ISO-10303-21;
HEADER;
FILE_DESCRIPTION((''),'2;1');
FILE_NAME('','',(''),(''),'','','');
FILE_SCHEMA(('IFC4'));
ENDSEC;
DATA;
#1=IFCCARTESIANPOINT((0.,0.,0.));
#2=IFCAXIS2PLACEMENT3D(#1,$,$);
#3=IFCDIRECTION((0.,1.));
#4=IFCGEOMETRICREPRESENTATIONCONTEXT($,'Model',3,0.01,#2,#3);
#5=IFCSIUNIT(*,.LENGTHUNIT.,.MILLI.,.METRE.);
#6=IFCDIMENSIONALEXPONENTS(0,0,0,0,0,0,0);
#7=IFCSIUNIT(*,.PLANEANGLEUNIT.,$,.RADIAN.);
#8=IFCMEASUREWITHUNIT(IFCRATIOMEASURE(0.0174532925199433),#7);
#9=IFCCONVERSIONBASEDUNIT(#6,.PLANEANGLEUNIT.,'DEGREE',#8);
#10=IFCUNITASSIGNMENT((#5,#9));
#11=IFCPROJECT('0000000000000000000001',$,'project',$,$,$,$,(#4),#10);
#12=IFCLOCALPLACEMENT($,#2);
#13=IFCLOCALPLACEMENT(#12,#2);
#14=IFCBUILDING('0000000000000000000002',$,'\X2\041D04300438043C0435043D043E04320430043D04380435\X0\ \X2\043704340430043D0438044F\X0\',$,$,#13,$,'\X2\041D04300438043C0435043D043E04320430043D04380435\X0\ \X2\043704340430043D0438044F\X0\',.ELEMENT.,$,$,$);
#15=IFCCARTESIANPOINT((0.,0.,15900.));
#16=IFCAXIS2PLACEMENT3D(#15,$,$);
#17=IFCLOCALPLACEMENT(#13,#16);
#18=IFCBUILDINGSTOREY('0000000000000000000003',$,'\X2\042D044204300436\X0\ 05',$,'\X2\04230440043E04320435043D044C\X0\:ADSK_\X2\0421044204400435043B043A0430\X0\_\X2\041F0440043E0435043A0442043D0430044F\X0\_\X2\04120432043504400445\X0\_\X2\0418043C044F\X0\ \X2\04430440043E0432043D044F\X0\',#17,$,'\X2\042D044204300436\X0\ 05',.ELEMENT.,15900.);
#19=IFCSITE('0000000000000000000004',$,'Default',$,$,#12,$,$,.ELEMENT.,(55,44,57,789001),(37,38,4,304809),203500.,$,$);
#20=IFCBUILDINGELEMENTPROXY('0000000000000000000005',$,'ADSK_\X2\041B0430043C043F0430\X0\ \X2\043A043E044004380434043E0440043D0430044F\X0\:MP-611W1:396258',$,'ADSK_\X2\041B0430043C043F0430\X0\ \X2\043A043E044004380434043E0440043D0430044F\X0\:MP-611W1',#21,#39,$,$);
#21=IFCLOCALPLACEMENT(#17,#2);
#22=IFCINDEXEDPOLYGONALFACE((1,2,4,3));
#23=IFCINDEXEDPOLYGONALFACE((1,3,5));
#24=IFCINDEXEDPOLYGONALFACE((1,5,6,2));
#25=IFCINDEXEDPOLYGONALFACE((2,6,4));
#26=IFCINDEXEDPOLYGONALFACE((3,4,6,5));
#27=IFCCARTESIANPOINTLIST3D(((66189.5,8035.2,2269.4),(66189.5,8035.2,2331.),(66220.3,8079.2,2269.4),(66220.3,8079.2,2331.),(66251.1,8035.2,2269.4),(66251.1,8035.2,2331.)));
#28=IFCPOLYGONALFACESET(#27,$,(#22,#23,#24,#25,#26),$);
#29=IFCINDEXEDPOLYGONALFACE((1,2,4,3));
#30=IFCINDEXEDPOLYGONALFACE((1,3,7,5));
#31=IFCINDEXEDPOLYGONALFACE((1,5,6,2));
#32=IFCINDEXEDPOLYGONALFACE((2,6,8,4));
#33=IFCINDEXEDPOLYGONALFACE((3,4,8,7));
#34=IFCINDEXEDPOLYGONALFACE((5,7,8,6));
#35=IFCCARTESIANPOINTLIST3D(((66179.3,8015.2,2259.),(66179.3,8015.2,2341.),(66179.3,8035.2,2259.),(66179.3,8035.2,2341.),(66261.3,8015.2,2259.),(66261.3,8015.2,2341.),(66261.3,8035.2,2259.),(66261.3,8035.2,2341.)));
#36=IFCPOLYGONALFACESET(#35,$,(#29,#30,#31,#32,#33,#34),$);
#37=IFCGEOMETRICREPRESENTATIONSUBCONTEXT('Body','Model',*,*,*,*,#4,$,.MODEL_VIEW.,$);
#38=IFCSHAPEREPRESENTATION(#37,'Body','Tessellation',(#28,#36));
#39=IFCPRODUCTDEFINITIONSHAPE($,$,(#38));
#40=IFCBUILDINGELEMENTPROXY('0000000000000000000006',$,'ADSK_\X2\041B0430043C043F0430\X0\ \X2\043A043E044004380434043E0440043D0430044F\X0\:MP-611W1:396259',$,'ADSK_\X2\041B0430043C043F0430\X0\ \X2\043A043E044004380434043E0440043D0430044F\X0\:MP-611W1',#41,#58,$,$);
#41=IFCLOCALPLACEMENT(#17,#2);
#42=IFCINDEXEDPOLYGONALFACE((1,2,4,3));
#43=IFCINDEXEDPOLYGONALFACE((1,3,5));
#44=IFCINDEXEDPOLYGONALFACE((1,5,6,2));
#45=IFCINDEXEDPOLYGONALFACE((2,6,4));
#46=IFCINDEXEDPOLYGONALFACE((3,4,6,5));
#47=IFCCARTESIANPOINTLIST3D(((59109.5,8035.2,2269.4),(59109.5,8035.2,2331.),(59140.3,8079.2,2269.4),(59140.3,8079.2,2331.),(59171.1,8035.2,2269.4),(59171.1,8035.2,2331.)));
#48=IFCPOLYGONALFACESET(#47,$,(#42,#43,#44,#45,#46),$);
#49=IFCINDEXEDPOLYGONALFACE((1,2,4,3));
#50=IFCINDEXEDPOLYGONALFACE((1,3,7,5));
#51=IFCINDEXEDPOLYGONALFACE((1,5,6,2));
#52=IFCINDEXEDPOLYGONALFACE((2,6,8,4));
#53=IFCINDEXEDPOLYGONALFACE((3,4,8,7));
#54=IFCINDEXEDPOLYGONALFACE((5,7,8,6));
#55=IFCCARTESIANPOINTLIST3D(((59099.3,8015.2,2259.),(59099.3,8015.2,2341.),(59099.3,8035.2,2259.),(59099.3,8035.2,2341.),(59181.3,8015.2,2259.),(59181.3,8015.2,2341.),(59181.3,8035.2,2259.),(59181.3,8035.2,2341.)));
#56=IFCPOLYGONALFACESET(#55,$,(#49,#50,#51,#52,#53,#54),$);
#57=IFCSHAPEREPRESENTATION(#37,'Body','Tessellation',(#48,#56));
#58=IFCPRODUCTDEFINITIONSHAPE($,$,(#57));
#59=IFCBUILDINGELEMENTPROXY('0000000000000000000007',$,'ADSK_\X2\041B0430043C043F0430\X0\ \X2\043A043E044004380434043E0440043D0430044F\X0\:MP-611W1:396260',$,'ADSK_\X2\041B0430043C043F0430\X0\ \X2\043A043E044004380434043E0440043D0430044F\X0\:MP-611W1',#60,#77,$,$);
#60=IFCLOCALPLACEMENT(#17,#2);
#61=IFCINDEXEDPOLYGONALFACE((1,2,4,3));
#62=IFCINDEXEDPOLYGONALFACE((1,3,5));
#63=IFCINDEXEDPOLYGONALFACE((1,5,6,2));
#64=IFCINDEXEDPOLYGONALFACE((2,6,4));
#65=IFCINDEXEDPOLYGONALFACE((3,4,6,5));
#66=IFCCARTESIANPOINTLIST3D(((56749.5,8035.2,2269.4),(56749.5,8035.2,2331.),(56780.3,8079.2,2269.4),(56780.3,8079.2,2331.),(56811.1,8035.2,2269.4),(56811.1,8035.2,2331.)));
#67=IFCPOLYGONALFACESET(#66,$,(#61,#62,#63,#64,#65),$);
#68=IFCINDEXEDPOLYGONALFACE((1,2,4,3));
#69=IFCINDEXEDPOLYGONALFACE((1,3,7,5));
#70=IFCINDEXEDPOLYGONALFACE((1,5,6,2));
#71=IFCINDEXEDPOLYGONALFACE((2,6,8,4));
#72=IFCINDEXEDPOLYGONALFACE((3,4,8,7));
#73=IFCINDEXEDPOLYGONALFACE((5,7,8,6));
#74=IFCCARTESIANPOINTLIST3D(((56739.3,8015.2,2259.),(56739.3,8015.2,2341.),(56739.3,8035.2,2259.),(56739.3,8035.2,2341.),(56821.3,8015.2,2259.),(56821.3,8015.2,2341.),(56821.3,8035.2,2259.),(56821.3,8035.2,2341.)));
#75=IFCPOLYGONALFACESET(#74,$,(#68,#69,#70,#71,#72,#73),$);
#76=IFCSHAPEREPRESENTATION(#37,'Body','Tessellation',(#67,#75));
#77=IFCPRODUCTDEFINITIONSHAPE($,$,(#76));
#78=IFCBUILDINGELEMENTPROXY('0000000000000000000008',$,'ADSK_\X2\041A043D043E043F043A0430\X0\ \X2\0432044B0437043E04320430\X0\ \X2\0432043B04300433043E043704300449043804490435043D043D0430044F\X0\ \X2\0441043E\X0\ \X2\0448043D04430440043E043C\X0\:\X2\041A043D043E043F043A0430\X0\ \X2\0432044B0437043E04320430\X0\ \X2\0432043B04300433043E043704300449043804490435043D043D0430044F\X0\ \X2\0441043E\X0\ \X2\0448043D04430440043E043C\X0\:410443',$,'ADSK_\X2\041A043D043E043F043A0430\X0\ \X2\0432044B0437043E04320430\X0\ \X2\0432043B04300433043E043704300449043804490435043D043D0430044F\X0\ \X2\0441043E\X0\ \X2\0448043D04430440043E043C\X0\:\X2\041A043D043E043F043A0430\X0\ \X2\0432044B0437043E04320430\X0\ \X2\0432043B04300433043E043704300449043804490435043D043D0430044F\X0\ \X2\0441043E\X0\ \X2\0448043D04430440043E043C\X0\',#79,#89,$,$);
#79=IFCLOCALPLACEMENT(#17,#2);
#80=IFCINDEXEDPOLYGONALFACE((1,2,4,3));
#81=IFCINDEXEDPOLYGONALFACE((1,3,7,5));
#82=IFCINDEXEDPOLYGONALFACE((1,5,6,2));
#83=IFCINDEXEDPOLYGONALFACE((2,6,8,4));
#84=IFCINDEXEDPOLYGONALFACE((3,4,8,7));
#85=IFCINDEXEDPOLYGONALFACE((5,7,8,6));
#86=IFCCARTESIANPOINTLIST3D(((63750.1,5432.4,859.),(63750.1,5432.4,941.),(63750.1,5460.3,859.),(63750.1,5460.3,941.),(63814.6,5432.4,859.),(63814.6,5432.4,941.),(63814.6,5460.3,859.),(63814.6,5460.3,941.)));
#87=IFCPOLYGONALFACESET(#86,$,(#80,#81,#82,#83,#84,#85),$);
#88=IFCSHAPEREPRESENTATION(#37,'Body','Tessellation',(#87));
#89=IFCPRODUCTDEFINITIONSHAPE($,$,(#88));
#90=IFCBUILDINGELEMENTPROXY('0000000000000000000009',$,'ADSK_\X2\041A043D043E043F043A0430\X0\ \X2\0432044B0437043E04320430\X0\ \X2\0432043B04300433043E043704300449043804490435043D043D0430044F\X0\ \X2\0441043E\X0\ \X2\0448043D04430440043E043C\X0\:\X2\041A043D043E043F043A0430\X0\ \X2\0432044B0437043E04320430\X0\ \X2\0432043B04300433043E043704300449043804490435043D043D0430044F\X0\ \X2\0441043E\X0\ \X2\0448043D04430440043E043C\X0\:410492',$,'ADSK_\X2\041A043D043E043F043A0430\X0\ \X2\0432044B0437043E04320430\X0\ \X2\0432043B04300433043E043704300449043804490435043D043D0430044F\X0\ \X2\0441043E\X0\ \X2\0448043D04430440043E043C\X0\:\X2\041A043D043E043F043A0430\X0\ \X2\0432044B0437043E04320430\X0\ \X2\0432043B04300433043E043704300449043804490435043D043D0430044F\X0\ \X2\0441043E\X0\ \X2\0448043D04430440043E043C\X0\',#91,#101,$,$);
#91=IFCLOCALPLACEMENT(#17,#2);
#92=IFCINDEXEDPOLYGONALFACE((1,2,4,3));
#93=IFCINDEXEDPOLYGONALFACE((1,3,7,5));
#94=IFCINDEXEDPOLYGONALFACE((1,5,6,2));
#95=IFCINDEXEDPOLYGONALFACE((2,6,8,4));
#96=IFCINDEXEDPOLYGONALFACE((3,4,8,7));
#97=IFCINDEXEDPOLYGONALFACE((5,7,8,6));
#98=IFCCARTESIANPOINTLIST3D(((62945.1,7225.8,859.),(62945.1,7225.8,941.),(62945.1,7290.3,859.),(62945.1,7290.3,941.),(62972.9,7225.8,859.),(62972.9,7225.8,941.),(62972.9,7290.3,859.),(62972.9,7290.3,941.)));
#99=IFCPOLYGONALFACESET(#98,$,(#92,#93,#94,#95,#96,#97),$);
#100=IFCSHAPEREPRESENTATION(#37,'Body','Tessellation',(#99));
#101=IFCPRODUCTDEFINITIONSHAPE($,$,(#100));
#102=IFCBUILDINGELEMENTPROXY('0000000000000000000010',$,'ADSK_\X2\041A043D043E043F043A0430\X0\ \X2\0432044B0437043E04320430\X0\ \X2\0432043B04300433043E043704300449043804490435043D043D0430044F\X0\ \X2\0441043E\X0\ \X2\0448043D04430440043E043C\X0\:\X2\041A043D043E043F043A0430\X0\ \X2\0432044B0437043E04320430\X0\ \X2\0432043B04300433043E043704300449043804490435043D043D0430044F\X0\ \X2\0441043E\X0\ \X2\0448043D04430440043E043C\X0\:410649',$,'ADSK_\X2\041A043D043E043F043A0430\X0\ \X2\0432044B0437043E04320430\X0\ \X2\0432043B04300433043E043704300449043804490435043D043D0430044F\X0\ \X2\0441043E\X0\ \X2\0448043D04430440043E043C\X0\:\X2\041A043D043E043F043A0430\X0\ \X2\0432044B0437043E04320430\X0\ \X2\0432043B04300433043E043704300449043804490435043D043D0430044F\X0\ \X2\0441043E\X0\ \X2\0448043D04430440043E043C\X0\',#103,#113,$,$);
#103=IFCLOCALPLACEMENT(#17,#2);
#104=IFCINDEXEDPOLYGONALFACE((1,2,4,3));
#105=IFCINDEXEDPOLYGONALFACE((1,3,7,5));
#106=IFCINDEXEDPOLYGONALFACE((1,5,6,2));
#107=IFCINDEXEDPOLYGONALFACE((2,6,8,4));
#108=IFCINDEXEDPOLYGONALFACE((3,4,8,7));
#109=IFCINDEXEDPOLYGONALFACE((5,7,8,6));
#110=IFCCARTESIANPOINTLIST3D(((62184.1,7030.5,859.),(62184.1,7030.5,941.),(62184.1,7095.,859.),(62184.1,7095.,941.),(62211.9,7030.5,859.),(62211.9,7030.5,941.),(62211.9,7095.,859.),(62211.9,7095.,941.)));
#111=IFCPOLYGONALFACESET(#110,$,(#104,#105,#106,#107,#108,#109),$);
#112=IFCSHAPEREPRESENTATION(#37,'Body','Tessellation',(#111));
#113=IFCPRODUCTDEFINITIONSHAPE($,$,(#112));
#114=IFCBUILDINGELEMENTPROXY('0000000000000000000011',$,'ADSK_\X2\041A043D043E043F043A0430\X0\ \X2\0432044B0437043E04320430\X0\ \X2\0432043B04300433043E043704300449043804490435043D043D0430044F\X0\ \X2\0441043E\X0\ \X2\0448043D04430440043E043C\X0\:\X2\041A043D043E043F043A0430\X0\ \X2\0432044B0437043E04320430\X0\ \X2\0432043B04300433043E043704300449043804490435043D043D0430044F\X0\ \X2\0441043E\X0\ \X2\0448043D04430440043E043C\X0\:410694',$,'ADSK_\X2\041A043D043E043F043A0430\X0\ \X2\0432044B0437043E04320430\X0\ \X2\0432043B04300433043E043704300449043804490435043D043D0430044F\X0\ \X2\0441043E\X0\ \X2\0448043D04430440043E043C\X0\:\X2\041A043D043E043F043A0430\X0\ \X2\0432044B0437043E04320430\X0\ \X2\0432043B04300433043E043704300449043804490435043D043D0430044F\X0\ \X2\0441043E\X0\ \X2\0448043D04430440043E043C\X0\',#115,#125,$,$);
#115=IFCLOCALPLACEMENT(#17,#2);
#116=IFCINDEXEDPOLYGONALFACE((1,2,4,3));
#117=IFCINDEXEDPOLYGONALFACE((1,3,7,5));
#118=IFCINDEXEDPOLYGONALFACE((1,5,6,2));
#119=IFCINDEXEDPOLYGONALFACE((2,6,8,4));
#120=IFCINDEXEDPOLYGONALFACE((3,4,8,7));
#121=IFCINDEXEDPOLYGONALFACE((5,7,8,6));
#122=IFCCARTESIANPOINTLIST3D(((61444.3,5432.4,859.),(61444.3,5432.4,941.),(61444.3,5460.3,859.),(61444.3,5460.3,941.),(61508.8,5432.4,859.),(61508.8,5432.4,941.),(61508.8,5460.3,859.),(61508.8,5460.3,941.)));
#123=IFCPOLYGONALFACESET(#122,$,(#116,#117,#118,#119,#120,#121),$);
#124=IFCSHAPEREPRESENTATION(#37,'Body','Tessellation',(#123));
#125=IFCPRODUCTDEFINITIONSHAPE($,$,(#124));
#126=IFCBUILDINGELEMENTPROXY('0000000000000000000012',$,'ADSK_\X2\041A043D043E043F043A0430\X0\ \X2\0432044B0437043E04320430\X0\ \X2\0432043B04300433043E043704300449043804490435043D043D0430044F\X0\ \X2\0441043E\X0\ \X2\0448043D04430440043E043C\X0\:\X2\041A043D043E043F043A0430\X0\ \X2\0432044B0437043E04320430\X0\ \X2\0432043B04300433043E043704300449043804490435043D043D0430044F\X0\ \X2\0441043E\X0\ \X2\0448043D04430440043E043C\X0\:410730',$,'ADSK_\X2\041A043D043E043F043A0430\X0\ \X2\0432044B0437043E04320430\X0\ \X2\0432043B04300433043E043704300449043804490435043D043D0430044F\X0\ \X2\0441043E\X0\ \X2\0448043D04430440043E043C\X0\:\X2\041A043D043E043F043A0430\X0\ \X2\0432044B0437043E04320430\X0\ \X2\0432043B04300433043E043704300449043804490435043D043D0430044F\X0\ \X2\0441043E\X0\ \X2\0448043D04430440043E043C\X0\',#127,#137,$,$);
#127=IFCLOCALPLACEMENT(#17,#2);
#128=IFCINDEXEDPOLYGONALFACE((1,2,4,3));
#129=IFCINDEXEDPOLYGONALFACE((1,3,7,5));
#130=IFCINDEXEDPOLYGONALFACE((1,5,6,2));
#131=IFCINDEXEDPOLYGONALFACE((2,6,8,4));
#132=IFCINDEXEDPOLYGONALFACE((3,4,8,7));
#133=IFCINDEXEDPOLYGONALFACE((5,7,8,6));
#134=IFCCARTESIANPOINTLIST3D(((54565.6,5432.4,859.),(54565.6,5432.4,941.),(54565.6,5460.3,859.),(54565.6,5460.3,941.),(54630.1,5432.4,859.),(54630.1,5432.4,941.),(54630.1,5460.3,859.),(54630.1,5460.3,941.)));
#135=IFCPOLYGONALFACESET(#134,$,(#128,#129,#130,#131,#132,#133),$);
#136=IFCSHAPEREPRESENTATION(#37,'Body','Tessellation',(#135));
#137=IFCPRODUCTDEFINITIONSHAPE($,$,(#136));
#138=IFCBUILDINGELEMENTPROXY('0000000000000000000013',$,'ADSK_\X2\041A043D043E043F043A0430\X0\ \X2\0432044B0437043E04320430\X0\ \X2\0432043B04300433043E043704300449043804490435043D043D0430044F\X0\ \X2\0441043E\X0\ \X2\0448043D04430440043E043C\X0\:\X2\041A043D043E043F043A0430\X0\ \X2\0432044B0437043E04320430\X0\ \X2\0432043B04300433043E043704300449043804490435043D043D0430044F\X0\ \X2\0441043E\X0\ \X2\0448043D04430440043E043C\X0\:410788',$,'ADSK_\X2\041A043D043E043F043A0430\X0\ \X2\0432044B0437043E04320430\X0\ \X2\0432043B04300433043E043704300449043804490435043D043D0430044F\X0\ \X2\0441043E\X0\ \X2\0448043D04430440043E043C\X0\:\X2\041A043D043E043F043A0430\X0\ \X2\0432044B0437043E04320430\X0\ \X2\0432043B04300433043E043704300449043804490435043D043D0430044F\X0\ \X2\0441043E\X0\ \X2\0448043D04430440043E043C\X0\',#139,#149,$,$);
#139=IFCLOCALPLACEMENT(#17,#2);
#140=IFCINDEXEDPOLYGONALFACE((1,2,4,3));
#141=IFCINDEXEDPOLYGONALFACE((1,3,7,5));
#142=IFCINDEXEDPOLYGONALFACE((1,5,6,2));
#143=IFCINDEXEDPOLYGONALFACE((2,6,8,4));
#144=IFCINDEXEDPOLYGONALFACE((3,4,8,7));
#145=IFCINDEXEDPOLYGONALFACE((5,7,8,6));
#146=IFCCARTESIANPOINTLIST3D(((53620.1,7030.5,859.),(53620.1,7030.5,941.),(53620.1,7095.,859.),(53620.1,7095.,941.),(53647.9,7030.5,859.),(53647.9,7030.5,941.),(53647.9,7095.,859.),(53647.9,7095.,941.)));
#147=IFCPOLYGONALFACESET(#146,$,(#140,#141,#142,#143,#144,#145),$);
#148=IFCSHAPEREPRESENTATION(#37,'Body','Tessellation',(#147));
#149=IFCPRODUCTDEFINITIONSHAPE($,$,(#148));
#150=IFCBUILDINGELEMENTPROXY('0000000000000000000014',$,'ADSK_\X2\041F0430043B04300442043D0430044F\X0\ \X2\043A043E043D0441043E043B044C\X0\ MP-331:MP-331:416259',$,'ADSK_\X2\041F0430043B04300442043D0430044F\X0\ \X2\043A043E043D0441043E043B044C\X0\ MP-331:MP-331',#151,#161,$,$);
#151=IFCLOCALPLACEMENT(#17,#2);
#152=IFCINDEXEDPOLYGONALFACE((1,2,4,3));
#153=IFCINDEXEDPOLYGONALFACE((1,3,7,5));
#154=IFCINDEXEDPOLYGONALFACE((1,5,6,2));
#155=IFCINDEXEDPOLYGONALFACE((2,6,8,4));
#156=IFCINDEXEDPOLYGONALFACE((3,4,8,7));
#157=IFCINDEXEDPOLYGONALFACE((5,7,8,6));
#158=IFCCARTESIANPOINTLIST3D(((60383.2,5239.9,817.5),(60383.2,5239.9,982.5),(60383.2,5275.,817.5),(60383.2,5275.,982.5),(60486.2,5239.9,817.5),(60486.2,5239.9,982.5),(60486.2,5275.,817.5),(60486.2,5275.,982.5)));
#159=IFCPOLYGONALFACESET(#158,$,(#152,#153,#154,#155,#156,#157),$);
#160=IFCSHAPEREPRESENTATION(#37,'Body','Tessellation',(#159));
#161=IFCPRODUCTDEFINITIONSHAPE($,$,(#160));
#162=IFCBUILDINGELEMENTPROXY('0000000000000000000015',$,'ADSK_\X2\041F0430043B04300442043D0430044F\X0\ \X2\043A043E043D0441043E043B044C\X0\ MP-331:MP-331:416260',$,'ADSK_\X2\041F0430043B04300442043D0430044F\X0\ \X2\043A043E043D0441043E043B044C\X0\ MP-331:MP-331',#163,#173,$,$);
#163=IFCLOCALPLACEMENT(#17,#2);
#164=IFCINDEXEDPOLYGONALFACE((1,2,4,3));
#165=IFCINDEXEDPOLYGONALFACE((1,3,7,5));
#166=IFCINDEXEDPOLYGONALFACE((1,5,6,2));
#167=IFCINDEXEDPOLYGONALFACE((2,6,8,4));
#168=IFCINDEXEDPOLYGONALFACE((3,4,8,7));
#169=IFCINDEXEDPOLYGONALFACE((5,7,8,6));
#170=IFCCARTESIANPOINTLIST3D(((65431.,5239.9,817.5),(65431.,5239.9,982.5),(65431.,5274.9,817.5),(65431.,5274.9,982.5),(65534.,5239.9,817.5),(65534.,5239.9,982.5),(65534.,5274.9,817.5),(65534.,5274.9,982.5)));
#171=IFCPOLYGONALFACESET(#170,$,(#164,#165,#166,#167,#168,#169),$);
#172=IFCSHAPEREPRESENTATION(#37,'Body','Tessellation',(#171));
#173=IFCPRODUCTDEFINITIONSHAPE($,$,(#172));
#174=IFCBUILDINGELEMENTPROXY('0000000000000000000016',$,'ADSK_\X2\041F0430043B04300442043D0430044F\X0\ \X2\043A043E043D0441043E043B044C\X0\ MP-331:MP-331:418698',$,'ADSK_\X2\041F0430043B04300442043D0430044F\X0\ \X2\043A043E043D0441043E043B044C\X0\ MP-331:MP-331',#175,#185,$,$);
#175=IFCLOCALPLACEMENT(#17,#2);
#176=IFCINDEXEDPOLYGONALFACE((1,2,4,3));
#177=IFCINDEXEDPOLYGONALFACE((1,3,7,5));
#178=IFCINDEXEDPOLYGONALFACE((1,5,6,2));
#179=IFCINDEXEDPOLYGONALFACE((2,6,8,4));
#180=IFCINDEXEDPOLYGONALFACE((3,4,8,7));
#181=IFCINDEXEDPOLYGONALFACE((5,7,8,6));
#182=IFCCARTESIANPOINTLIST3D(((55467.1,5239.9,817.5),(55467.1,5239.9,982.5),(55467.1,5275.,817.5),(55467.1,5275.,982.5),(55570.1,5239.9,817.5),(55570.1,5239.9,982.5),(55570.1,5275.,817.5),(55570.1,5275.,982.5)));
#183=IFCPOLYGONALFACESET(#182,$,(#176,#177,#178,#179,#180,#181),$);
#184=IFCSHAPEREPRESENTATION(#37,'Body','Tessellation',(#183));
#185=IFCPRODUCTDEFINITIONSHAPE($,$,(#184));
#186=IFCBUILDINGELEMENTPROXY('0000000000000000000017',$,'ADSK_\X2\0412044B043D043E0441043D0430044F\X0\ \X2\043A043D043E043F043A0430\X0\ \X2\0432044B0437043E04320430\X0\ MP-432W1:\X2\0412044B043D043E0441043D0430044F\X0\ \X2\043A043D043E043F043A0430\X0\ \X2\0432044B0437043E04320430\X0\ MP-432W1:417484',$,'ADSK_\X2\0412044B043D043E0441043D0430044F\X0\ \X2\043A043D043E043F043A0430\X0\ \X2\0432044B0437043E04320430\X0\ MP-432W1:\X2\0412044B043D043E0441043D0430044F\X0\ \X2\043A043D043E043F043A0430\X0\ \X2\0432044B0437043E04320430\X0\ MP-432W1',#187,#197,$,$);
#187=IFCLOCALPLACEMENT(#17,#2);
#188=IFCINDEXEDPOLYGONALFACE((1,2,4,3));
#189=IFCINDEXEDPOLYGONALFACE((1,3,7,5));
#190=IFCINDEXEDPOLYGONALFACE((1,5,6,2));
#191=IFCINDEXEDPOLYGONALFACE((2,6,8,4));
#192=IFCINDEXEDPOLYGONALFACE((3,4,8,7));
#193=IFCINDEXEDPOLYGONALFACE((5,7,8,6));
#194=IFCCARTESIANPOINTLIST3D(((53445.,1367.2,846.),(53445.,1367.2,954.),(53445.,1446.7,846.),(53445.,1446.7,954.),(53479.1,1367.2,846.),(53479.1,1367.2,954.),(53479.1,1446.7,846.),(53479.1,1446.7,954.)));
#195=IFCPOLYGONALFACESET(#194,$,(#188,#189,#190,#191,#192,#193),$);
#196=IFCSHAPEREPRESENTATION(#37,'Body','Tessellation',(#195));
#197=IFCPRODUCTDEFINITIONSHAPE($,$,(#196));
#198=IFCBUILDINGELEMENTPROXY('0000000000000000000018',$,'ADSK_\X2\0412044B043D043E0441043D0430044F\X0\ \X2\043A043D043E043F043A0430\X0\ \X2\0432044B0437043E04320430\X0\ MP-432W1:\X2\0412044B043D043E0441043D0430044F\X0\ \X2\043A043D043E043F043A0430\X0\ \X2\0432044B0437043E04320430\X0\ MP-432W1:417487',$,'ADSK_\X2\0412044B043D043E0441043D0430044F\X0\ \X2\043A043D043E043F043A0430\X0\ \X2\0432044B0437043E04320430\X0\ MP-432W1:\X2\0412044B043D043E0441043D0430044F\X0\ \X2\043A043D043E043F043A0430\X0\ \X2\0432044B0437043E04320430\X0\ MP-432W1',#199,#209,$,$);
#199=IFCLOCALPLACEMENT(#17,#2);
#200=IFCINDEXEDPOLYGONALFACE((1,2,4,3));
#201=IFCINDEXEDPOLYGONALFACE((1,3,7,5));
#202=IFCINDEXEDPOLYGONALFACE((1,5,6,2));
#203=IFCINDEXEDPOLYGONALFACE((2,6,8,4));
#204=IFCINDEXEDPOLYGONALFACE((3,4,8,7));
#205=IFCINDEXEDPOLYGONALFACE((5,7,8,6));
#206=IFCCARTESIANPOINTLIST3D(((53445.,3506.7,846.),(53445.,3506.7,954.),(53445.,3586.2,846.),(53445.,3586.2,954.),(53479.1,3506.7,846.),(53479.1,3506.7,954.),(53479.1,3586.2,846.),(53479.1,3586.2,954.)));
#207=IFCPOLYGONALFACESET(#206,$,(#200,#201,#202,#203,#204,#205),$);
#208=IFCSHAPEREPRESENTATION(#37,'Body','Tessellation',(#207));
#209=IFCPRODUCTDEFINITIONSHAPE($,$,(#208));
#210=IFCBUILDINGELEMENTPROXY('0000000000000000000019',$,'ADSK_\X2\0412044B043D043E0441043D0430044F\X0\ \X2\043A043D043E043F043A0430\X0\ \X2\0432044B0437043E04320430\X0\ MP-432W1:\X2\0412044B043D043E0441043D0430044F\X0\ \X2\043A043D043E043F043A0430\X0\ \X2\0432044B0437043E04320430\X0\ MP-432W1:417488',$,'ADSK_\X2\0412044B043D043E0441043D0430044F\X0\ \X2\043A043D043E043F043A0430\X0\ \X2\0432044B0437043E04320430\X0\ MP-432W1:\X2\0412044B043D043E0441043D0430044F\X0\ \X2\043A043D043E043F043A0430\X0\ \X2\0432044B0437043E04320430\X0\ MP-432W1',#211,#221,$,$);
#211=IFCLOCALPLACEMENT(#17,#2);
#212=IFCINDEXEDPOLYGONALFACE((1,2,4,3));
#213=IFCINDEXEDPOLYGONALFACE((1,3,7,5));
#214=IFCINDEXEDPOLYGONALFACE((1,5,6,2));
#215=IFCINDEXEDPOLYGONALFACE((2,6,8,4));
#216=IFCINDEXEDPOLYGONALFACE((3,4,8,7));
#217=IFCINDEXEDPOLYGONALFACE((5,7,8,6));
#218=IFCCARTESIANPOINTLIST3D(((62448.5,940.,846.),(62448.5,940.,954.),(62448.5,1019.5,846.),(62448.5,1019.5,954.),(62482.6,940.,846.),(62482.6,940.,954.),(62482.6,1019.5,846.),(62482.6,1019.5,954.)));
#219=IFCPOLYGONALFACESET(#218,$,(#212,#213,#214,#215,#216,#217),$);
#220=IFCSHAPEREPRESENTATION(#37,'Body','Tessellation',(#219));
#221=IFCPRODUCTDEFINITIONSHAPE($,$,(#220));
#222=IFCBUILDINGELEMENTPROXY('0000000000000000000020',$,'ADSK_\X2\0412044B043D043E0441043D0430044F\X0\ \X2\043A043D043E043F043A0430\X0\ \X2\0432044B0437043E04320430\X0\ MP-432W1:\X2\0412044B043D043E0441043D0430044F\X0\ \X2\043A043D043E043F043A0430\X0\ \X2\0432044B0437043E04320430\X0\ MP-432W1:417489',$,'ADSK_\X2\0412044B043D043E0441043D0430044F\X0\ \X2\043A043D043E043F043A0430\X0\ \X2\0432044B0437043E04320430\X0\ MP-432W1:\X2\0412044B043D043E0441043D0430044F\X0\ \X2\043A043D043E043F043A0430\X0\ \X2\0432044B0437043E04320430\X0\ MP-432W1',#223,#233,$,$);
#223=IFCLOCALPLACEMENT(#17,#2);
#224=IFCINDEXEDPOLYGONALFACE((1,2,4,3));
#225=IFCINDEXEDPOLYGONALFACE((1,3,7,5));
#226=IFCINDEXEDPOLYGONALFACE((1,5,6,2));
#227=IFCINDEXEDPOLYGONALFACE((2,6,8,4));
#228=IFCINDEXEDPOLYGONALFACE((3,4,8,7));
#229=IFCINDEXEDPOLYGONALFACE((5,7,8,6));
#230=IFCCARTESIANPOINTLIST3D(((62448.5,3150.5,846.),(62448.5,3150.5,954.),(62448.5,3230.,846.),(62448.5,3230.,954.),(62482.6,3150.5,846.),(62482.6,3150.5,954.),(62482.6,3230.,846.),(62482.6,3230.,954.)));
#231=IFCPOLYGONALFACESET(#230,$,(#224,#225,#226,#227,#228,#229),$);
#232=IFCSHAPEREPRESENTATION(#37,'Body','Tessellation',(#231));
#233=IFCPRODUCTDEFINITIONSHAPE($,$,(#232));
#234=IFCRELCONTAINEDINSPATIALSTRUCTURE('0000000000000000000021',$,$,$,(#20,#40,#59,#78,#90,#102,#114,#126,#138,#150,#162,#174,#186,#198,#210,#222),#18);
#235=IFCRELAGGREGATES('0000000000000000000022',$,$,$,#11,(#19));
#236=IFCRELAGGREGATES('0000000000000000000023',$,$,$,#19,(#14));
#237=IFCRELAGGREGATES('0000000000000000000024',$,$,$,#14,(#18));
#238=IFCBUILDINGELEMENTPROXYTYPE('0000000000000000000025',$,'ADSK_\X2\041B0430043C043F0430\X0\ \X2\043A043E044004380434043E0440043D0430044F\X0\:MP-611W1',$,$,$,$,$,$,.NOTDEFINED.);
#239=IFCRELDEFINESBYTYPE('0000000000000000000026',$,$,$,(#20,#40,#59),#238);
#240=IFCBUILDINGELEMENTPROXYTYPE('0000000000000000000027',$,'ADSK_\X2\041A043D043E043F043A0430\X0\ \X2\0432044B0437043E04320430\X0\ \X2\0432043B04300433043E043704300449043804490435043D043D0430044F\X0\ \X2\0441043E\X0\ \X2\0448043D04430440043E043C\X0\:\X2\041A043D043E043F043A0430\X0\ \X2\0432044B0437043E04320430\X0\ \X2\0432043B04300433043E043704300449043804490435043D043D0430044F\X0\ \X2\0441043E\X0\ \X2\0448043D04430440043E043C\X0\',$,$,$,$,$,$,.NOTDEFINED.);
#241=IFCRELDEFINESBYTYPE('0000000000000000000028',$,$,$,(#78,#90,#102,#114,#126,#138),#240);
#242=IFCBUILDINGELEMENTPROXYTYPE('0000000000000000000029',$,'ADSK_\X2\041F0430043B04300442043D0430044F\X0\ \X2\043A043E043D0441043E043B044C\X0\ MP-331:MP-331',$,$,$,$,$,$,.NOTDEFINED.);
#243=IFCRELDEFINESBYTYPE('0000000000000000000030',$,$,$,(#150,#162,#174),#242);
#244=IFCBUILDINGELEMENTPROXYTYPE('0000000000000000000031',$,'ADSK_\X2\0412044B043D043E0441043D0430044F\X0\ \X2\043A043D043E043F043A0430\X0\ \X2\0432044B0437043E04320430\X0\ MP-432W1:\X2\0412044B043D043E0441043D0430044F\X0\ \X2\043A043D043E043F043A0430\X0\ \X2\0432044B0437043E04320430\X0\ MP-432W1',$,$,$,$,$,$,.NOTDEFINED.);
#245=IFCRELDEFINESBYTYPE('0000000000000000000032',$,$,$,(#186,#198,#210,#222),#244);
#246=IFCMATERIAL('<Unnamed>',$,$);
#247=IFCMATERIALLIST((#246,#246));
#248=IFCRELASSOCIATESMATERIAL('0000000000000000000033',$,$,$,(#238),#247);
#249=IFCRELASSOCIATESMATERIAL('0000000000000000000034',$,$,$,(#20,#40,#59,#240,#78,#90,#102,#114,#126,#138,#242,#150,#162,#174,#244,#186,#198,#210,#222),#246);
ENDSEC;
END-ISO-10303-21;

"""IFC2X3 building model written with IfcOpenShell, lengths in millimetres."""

from ifc_helpers import new_model, entity, si_unit, converted_unit, direction, frame, origin, origin_2d_with_axis, place, context, subcontext, project, spatial, polyline, rectangle, outline, extrude, source, transform, mapped, material, material_list, type_object, type_shapes, element, save


model = new_model("IFC2X3")

# Units and contexts
model_context = context("Model", 3, precision=0.01, world=origin(), true_north=direction((0.0, 1.0)))
body_context = subcontext(model_context, "Body", "Model", "MODEL_VIEW")
ifc_project = project(units=[si_unit("LENGTHUNIT", "METRE", prefix="MILLI"), converted_unit("PLANEANGLEUNIT", "DEGREE", entity("IfcRatioMeasure", 0.0174532925199433), si_unit("PLANEANGLEUNIT", "RADIAN"), dimensions=[0, 0, 0, 0, 0, 0, 0])], contexts=[model_context])

# Site, building, storey
site_placement = place(None, origin())
site = spatial("IfcSite", under=ifc_project, at=site_placement, Name="Default", CompositionType="ELEMENT", RefLatitude=(55, 44, 57, 789001), RefLongitude=(37, 38, 4, 304809), RefElevation=203500.0)
building_placement = place(site_placement, origin())
building = spatial("IfcBuilding", under=site, at=building_placement, Name="Наименование здания", LongName="Наименование здания", CompositionType="ELEMENT")
storey_placement = place(building_placement, frame((0.0, 0.0, 15900.0)))
storey = spatial("IfcBuildingStorey", under=building, at=storey_placement, Name="Этаж 05", ObjectType="Уровень:ADSK_Стрелка_Проектная_Вверх_Имя уровня", LongName="Этаж 05", CompositionType="ELEMENT", Elevation=15900.0)

# Building element proxies
ifc_material = material(Name="<Unnamed>")
ifc_material_list = material_list([ifc_material, ifc_material])
building_element_proxy_type_1 = type_object("IfcBuildingElementProxyType", Name="ADSK_Лампа коридорная:MP-611W1", PredefinedType="NOTDEFINED", material=ifc_material_list)
shared_shape_1 = source(origin(), body_context, "Body", "SweptSolid", [
    extrude(outline(polyline([(-30.8, -14.7), (30.8, -14.7), (0.0, 29.3), (-30.8, -14.7)])), frame((0.0, -2.7, -30.6), z_axis=(0.0, 0.0, 1.0), x_axis=(-1.0, 0.0, 0.0)), (0.0, 0.0, 1.0), 61.6),
    extrude(rectangle(XDim=82.0, YDim=20.0, at=origin_2d_with_axis()), frame((0.0, 22.0, -41.0), z_axis=(0.0, 0.0, 1.0), x_axis=(-1.0, 0.0, 0.0)), (0.0, 0.0, 1.0), 82.0),
])
type_shapes(building_element_proxy_type_1, [shared_shape_1])
for number, where, z_axis, x_axis, name in (
    (1, (66220.3, 8047.1, 2300.0), (0.0, 0.0, 1.0), (-1.0, 0.0, 0.0), "ADSK_Лампа коридорная:MP-611W1:396258"),
    (2, (59140.3, 8047.1, 2300.0), (0.0, 0.0, 1.0), (-1.0, 0.0, 0.0), "ADSK_Лампа коридорная:MP-611W1:396259"),
    (3, (56780.3, 8047.1, 2300.0), (0.0, 0.0, 1.0), (-1.0, 0.0, 0.0), "ADSK_Лампа коридорная:MP-611W1:396260"),
):
    element("IfcBuildingElementProxy", number, at=place(storey_placement, frame(where, z_axis=z_axis, x_axis=x_axis)), inside=storey, type_object=building_element_proxy_type_1, material=ifc_material, Name=name, ObjectType="ADSK_Лампа коридорная:MP-611W1", context=body_context, shape_type="MappedRepresentation", body=[
        mapped(shared_shape_1, transform((0.0, 0.0, 0.0), scale=1.0)),
    ])
building_element_proxy_type_2 = type_object("IfcBuildingElementProxyType", Name="ADSK_Кнопка вызова влагозащищенная со шнуром:Кнопка вызова влагозащищенная со шнуром", PredefinedType="NOTDEFINED", material=ifc_material)
shared_shape_2 = source(origin(), body_context, "Body", "SweptSolid", [
    extrude(rectangle(XDim=64.5, YDim=27.8, at=origin_2d_with_axis()), frame((32.2, 13.9, 0.0), z_axis=(0.0, 0.0, 1.0), x_axis=(-1.0, 0.0, 0.0)), (0.0, 0.0, 1.0), 82.0),
])
type_shapes(building_element_proxy_type_2, [shared_shape_2])
for number, where, z_axis, x_axis, name in (
    (4, (63814.6, 5460.3, 859.0), (0.0, 0.0, 1.0), (-1.0, 0.0, 0.0), "ADSK_Кнопка вызова влагозащищенная со шнуром:Кнопка вызова влагозащищенная со шнуром:410443"),
    (5, (62972.9, 7225.8, 859.0), (0.0, 0.0, 1.0), (0.0, 1.0, 0.0), "ADSK_Кнопка вызова влагозащищенная со шнуром:Кнопка вызова влагозащищенная со шнуром:410492"),
    (6, (62184.1, 7095.0, 859.0), (0.0, 0.0, 1.0), (0.0, -1.0, 0.0), "ADSK_Кнопка вызова влагозащищенная со шнуром:Кнопка вызова влагозащищенная со шнуром:410649"),
    (7, (61508.8, 5460.3, 859.0), (0.0, 0.0, 1.0), (-1.0, 0.0, 0.0), "ADSK_Кнопка вызова влагозащищенная со шнуром:Кнопка вызова влагозащищенная со шнуром:410694"),
    (8, (54630.1, 5460.3, 859.0), (0.0, 0.0, 1.0), (-1.0, 0.0, 0.0), "ADSK_Кнопка вызова влагозащищенная со шнуром:Кнопка вызова влагозащищенная со шнуром:410730"),
    (9, (53647.9, 7030.5, 859.0), (0.0, 0.0, 1.0), (0.0, 1.0, 0.0), "ADSK_Кнопка вызова влагозащищенная со шнуром:Кнопка вызова влагозащищенная со шнуром:410788"),
):
    element("IfcBuildingElementProxy", number, at=place(storey_placement, frame(where, z_axis=z_axis, x_axis=x_axis)), inside=storey, type_object=building_element_proxy_type_2, material=ifc_material, Name=name, ObjectType="ADSK_Кнопка вызова влагозащищенная со шнуром:Кнопка вызова влагозащищенная со шнуром", context=body_context, shape_type="MappedRepresentation", body=[
        mapped(shared_shape_2, transform((0.0, 0.0, 0.0), scale=1.0)),
    ])
building_element_proxy_type_3 = type_object("IfcBuildingElementProxyType", Name="ADSK_Палатная консоль MP-331:MP-331", PredefinedType="NOTDEFINED", material=ifc_material)
shared_shape_3 = source(origin(), body_context, "Body", "SweptSolid", [
    extrude(rectangle(XDim=103.0, YDim=35.0, at=origin_2d_with_axis()), frame((0.0, 14.5, -82.5), z_axis=(0.0, 0.0, 1.0), x_axis=(-1.0, 0.0, 0.0)), (0.0, 0.0, 1.0), 165.0),
])
type_shapes(building_element_proxy_type_3, [shared_shape_3])
for number, where, name in (
    (10, (60434.7, 5242.9, 900.0), "ADSK_Палатная консоль MP-331:MP-331:416259"),
    (11, (65482.5, 5242.9, 900.0), "ADSK_Палатная консоль MP-331:MP-331:416260"),
    (12, (55518.6, 5242.9, 900.0), "ADSK_Палатная консоль MP-331:MP-331:418698"),
):
    element("IfcBuildingElementProxy", number, at=place(storey_placement, frame(where)), inside=storey, type_object=building_element_proxy_type_3, material=ifc_material, Name=name, ObjectType="ADSK_Палатная консоль MP-331:MP-331", context=body_context, shape_type="MappedRepresentation", body=[
        mapped(shared_shape_3, transform((0.0, 0.0, 0.0), scale=1.0)),
    ])
building_element_proxy_type_4 = type_object("IfcBuildingElementProxyType", Name="ADSK_Выносная кнопка вызова MP-432W1:Выносная кнопка вызова MP-432W1", PredefinedType="NOTDEFINED", material=ifc_material)
shared_shape_4 = source(origin(), body_context, "Body", "SweptSolid", [
    extrude(rectangle(XDim=79.5, YDim=34.1, at=origin_2d_with_axis()), frame((0.0, 15.0, -54.0), z_axis=(0.0, 0.0, 1.0), x_axis=(-1.0, 0.0, 0.0)), (0.0, 0.0, 1.0), 108.0),
])
type_shapes(building_element_proxy_type_4, [shared_shape_4])
for number, where, z_axis, x_axis, name in (
    (13, (53477.0, 1406.9, 900.0), (0.0, 0.0, 1.0), (0.0, 1.0, 0.0), "ADSK_Выносная кнопка вызова MP-432W1:Выносная кнопка вызова MP-432W1:417484"),
    (14, (53477.0, 3546.5, 900.0), (0.0, 0.0, 1.0), (0.0, 1.0, 0.0), "ADSK_Выносная кнопка вызова MP-432W1:Выносная кнопка вызова MP-432W1:417487"),
    (15, (62450.6, 979.8, 900.0), (0.0, 0.0, 1.0), (0.0, -1.0, 0.0), "ADSK_Выносная кнопка вызова MP-432W1:Выносная кнопка вызова MP-432W1:417488"),
    (16, (62450.6, 3190.2, 900.0), (0.0, 0.0, 1.0), (0.0, -1.0, 0.0), "ADSK_Выносная кнопка вызова MP-432W1:Выносная кнопка вызова MP-432W1:417489"),
):
    element("IfcBuildingElementProxy", number, at=place(storey_placement, frame(where, z_axis=z_axis, x_axis=x_axis)), inside=storey, type_object=building_element_proxy_type_4, material=ifc_material, Name=name, ObjectType="ADSK_Выносная кнопка вызова MP-432W1:Выносная кнопка вызова MP-432W1", context=body_context, shape_type="MappedRepresentation", body=[
        mapped(shared_shape_4, transform((0.0, 0.0, 0.0), scale=1.0)),
    ])

save(model, "model.ifc")
